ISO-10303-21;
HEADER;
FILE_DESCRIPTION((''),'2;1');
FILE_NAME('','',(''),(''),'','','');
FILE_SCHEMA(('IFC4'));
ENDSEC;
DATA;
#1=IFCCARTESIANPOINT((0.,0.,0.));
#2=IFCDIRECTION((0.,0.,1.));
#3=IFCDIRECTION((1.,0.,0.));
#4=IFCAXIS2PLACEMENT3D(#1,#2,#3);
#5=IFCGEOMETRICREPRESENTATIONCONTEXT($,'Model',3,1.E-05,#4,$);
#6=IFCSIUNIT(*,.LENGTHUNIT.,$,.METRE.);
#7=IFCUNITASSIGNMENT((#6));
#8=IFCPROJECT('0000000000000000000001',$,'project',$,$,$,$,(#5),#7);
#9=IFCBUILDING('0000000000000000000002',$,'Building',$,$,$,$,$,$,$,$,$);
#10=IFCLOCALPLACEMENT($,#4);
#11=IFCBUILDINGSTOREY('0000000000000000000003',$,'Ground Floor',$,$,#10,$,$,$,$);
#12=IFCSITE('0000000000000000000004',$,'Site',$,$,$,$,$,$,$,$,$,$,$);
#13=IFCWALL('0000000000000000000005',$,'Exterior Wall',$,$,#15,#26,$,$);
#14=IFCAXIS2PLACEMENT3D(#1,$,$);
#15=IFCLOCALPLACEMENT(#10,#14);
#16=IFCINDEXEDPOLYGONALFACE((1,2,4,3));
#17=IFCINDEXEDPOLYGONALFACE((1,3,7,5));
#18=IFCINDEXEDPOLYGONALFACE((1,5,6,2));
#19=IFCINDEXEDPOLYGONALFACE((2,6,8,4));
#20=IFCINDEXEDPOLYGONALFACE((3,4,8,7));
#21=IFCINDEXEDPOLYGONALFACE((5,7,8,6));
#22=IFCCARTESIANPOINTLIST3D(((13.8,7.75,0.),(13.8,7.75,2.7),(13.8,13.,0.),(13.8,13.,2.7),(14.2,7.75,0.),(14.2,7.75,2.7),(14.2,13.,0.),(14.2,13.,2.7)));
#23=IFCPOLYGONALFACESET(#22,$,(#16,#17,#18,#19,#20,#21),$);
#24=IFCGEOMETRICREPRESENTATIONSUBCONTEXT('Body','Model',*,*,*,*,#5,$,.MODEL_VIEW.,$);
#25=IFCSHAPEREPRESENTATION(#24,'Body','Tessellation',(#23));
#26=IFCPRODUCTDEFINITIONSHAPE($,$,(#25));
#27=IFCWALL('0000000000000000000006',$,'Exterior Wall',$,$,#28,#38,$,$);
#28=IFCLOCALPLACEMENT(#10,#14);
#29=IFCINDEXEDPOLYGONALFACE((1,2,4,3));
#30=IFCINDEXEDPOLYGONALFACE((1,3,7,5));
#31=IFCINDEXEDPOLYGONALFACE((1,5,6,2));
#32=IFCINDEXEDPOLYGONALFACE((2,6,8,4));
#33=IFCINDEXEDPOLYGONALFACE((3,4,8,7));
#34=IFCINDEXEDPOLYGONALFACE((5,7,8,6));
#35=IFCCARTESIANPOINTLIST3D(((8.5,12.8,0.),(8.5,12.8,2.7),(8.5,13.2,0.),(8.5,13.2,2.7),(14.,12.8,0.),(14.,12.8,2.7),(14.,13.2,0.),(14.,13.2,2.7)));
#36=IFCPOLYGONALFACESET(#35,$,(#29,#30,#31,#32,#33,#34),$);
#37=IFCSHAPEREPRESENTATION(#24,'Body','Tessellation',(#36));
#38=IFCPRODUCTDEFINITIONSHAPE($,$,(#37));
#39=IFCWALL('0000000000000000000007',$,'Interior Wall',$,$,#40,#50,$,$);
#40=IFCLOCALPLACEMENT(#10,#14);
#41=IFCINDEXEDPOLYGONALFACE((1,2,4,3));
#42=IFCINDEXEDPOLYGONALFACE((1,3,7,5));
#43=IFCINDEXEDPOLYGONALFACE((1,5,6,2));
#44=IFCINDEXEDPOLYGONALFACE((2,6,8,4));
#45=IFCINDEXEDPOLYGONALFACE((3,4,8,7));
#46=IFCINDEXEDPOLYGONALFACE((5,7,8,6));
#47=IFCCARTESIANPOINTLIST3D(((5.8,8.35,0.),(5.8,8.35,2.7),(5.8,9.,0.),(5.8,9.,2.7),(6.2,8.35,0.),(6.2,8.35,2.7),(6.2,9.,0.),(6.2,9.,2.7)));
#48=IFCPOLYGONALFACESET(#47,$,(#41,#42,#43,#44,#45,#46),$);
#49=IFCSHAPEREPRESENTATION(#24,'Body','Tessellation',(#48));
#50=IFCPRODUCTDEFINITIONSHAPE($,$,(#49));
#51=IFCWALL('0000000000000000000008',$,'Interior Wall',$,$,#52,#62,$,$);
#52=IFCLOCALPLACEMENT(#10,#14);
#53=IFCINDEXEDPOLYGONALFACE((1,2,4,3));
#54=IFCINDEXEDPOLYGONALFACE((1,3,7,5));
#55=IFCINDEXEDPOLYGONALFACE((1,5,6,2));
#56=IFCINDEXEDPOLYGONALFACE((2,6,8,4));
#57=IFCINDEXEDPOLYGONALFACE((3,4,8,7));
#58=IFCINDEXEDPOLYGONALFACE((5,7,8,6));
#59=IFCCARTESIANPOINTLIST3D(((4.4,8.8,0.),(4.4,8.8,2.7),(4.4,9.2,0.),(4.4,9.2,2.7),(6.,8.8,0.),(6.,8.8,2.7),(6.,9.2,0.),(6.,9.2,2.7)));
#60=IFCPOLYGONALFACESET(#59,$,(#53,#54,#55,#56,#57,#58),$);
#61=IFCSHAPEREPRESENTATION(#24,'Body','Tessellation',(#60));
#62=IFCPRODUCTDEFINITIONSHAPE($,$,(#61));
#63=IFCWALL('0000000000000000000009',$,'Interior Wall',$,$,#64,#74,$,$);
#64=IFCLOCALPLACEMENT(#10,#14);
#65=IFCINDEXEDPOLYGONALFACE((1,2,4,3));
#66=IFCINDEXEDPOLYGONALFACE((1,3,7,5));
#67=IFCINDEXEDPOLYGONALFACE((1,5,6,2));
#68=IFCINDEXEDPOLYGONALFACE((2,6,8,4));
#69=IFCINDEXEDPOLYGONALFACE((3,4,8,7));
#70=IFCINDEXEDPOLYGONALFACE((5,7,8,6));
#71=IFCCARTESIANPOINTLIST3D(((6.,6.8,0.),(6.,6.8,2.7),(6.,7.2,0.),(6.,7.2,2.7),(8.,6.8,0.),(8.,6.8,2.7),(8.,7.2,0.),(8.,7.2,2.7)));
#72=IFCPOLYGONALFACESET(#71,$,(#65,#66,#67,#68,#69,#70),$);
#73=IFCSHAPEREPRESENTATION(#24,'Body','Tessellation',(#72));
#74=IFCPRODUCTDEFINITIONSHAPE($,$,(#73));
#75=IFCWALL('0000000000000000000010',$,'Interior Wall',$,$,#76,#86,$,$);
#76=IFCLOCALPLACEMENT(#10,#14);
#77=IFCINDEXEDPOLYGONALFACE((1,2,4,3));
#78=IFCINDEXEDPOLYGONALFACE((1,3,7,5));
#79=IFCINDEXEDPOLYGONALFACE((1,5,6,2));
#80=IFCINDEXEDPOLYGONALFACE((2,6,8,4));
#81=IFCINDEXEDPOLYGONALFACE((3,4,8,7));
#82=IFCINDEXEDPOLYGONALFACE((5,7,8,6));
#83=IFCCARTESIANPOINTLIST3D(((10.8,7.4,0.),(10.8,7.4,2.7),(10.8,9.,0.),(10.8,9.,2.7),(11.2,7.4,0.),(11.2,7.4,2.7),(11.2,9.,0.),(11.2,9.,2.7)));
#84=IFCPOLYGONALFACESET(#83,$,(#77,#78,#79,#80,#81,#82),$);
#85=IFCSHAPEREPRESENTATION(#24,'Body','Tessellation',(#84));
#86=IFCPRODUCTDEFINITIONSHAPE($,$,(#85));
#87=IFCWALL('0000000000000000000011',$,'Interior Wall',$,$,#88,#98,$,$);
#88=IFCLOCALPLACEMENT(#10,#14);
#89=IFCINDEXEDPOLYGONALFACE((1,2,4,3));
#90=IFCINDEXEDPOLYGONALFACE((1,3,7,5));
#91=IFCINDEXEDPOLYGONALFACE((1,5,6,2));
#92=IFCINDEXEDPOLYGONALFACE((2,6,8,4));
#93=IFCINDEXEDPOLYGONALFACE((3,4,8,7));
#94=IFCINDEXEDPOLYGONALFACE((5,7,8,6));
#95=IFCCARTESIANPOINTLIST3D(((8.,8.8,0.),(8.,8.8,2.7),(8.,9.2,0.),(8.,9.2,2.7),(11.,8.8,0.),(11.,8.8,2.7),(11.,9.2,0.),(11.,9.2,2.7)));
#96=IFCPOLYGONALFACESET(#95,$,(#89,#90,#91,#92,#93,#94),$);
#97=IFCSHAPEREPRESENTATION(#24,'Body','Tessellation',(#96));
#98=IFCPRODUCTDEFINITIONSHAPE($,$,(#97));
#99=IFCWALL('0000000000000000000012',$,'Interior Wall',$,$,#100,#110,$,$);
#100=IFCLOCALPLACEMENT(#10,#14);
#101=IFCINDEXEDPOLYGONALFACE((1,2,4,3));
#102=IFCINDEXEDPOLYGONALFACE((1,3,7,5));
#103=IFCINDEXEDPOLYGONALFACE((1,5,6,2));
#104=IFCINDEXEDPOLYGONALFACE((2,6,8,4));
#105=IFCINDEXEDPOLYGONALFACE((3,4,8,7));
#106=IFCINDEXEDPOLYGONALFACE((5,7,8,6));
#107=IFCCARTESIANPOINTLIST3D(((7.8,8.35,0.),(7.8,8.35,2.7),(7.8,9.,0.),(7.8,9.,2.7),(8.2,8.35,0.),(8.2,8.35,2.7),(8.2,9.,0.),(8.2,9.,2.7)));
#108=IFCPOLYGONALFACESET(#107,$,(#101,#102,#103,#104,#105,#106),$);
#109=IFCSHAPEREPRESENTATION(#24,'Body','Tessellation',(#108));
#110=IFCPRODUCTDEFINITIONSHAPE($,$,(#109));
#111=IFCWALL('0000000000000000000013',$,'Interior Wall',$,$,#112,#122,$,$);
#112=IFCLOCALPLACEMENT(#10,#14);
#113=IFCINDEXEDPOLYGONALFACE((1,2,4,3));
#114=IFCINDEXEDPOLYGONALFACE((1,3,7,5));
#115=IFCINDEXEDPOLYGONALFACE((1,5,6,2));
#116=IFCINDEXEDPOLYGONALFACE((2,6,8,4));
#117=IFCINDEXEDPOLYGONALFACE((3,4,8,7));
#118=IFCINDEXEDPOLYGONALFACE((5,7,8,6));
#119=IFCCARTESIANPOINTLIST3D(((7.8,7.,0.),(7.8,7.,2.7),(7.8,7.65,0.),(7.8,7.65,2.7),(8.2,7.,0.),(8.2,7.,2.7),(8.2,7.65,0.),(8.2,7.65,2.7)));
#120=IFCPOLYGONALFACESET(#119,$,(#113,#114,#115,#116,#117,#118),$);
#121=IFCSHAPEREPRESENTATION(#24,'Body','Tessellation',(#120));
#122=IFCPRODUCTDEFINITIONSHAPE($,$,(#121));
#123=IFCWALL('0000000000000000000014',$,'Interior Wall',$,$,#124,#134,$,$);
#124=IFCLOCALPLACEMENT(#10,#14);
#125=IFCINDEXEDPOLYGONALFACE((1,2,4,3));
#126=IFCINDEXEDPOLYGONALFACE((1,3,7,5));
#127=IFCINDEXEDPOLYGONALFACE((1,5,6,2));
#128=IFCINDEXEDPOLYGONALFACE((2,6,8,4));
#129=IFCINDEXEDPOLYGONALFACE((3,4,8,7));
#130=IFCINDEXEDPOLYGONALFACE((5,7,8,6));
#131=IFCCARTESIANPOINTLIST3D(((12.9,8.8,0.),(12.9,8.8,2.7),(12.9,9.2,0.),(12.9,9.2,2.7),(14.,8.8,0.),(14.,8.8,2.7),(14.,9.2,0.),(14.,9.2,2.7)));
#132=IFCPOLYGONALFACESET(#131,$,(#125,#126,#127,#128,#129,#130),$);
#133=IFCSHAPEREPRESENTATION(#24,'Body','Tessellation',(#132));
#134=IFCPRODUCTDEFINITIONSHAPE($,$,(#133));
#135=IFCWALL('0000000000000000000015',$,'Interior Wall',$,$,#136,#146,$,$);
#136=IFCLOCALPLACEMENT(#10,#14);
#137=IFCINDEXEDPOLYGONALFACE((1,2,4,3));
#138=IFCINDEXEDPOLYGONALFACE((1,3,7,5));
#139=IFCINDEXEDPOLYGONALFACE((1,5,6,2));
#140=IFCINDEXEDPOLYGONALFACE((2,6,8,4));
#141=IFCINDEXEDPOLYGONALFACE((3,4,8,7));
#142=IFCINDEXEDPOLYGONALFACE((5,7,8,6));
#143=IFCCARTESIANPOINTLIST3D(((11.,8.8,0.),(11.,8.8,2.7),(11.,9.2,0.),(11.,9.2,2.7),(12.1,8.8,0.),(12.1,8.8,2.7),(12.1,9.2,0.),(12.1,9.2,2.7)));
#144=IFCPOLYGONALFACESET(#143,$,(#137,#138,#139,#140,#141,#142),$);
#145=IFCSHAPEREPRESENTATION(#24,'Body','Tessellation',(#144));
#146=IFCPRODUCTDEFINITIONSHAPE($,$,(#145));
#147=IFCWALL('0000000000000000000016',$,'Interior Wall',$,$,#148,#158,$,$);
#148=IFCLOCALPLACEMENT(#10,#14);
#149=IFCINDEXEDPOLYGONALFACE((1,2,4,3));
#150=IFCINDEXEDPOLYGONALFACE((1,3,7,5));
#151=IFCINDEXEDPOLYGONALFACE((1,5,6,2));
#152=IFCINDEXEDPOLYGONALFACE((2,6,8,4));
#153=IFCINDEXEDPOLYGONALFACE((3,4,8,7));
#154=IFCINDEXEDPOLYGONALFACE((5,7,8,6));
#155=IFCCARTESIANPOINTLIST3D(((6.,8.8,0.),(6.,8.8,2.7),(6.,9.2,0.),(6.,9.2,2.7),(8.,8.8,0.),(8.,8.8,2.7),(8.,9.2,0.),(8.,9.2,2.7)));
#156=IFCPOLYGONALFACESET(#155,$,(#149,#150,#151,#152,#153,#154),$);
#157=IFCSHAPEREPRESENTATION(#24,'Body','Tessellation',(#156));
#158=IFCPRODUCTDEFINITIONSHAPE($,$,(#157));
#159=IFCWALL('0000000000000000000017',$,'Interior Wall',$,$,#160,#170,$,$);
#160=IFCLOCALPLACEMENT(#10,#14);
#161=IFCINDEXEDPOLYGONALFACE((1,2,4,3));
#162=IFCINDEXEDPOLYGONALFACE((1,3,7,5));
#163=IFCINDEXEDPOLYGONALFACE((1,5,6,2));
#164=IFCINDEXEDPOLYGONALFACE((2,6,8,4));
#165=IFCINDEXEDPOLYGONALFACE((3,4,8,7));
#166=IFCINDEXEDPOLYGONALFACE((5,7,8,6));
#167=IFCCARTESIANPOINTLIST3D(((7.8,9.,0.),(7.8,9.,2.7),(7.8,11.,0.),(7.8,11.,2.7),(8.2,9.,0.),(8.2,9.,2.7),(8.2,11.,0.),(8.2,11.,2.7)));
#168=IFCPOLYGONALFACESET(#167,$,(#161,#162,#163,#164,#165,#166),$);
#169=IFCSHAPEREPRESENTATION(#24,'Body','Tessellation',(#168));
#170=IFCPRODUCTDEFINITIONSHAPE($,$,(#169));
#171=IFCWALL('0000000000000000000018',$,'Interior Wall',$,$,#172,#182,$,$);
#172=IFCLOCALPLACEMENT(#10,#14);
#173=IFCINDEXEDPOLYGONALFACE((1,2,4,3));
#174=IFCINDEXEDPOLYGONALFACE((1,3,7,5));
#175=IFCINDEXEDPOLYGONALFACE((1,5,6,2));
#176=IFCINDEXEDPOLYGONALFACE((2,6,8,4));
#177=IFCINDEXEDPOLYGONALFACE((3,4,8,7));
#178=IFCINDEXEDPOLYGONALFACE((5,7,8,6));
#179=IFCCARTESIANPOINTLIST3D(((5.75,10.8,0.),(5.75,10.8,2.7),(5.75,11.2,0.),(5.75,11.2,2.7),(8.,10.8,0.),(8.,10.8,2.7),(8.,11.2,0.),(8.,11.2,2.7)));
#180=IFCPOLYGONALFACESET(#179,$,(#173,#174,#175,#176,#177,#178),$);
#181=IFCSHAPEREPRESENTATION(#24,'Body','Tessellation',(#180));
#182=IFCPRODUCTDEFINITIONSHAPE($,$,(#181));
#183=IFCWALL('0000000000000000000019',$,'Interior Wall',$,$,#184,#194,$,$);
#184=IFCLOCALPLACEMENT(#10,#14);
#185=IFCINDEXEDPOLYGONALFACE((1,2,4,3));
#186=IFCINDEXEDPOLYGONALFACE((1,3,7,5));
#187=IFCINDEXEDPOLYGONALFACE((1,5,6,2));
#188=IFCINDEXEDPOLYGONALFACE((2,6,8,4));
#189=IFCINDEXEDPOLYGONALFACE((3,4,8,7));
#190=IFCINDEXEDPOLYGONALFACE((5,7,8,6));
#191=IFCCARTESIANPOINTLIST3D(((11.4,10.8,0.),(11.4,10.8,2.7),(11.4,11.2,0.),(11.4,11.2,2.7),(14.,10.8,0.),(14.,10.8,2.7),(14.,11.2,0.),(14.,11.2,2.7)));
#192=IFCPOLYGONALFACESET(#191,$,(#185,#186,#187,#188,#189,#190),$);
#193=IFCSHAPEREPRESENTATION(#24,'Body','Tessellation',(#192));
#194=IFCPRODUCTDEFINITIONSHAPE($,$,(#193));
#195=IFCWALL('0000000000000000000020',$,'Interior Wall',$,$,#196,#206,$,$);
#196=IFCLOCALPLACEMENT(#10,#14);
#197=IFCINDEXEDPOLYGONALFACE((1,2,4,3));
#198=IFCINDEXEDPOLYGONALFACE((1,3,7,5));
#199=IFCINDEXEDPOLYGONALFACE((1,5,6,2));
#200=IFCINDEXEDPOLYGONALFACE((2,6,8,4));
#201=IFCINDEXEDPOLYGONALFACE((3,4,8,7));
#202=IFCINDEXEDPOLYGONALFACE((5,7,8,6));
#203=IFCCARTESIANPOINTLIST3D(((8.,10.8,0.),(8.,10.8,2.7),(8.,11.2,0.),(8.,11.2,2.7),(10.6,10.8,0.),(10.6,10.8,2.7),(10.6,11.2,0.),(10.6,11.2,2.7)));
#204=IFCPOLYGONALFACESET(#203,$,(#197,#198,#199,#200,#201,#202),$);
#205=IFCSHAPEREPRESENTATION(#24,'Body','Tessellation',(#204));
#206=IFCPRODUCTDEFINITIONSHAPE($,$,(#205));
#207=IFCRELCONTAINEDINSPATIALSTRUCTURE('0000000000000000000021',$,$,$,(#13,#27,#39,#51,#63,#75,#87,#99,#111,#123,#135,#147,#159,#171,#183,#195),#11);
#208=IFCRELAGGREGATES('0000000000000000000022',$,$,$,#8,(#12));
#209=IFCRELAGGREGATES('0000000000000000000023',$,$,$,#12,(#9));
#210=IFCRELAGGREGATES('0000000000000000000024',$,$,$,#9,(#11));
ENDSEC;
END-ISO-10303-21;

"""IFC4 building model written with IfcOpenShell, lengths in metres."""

from ifc_helpers import new_model, si_unit, frame, origin_with_axes, place, context, subcontext, project, spatial, indexed_curve, outline, extrude, element, save


model = new_model("IFC4")

# Units and contexts
model_context = context("Model", 3, precision=1e-05, world=origin_with_axes())
body_context = subcontext(model_context, "Body", "Model", "MODEL_VIEW")
ifc_project = project(units=[si_unit("LENGTHUNIT", "METRE")], contexts=[model_context])

# Site, building, storey
site = spatial("IfcSite", under=ifc_project, Name="Site")
building = spatial("IfcBuilding", under=site, Name="Building")
storey_placement = place(None, origin_with_axes())
storey = spatial("IfcBuildingStorey", under=building, at=storey_placement, Name="Ground Floor")

# Walls
wall_1_placement = place(storey_placement, frame((14.0, 7.75, 0.0), z_axis=(0.0, 0.0, 1.0), x_axis=(0.0, 1.0, 0.0)))
element("IfcWall", 1, at=wall_1_placement, inside=storey, Name="Exterior Wall", context=body_context, shape_type="SweptSolid", body=[
    extrude(outline(indexed_curve([(0.0, 0.0), (0.0, 0.4), (5.25, 0.4), (5.25, 0.0), (0.0, 0.0)], self_intersect=False)), frame((0.0, -0.2, 0.0), z_axis=(0.0, 0.0, 1.0), x_axis=(1.0, 0.0, 0.0)), (0.0, 0.0, 1.0), 2.7),
])
wall_2_placement = place(storey_placement, frame((14.0, 13.0, 0.0), z_axis=(0.0, 0.0, 1.0), x_axis=(-1.0, 0.0, 0.0)))
element("IfcWall", 2, at=wall_2_placement, inside=storey, Name="Exterior Wall", context=body_context, shape_type="SweptSolid", body=[
    extrude(outline(indexed_curve([(0.0, 0.0), (0.0, 0.4), (5.5, 0.4), (5.5, 0.0), (0.0, 0.0)], self_intersect=False)), frame((0.0, -0.2, 0.0), z_axis=(0.0, 0.0, 1.0), x_axis=(1.0, 0.0, 0.0)), (0.0, 0.0, 1.0), 2.7),
])
wall_3_placement = place(storey_placement, frame((6.0, 8.35, 0.0), z_axis=(0.0, 0.0, 1.0), x_axis=(0.0, 1.0, 0.0)))
element("IfcWall", 3, at=wall_3_placement, inside=storey, Name="Interior Wall", context=body_context, shape_type="SweptSolid", body=[
    extrude(outline(indexed_curve([(0.0, 0.0), (0.0, 0.4), (0.65, 0.4), (0.65, 0.0), (0.0, 0.0)], self_intersect=False)), frame((0.0, -0.2, 0.0), z_axis=(0.0, 0.0, 1.0), x_axis=(1.0, 0.0, 0.0)), (0.0, 0.0, 1.0), 2.7),
])
wall_4_placement = place(storey_placement, frame((6.0, 9.0, 0.0), z_axis=(0.0, 0.0, 1.0), x_axis=(-1.0, 0.0, 0.0)))
element("IfcWall", 4, at=wall_4_placement, inside=storey, Name="Interior Wall", context=body_context, shape_type="SweptSolid", body=[
    extrude(outline(indexed_curve([(0.0, 0.0), (0.0, 0.4), (1.6, 0.4), (1.6, 0.0), (0.0, 0.0)], self_intersect=False)), frame((0.0, -0.2, 0.0), z_axis=(0.0, 0.0, 1.0), x_axis=(1.0, 0.0, 0.0)), (0.0, 0.0, 1.0), 2.7),
])
wall_5_placement = place(storey_placement, frame((8.0, 7.0, 0.0), z_axis=(0.0, 0.0, 1.0), x_axis=(-1.0, 0.0, 0.0)))
element("IfcWall", 5, at=wall_5_placement, inside=storey, Name="Interior Wall", context=body_context, shape_type="SweptSolid", body=[
    extrude(outline(indexed_curve([(0.0, 0.0), (0.0, 0.4), (2.0, 0.4), (2.0, 0.0), (0.0, 0.0)], self_intersect=False)), frame((0.0, -0.2, 0.0), z_axis=(0.0, 0.0, 1.0), x_axis=(1.0, 0.0, 0.0)), (0.0, 0.0, 1.0), 2.7),
])
wall_6_placement = place(storey_placement, frame((11.0, 7.4, 0.0), z_axis=(0.0, 0.0, 1.0), x_axis=(0.0, 1.0, 0.0)))
element("IfcWall", 6, at=wall_6_placement, inside=storey, Name="Interior Wall", context=body_context, shape_type="SweptSolid", body=[
    extrude(outline(indexed_curve([(0.0, 0.0), (0.0, 0.4), (1.6, 0.4), (1.6, 0.0), (0.0, 0.0)], self_intersect=False)), frame((0.0, -0.2, 0.0), z_axis=(0.0, 0.0, 1.0), x_axis=(1.0, 0.0, 0.0)), (0.0, 0.0, 1.0), 2.7),
])
wall_7_placement = place(storey_placement, frame((11.0, 9.0, 0.0), z_axis=(0.0, 0.0, 1.0), x_axis=(-1.0, 0.0, 0.0)))
element("IfcWall", 7, at=wall_7_placement, inside=storey, Name="Interior Wall", context=body_context, shape_type="SweptSolid", body=[
    extrude(outline(indexed_curve([(0.0, 0.0), (0.0, 0.4), (3.0, 0.4), (3.0, 0.0), (0.0, 0.0)], self_intersect=False)), frame((0.0, -0.2, 0.0), z_axis=(0.0, 0.0, 1.0), x_axis=(1.0, 0.0, 0.0)), (0.0, 0.0, 1.0), 2.7),
])
for number, where, z_axis, x_axis, name in (
    (8, (8.0, 9.0, 0.0), (0.0, 0.0, 1.0), (0.0, -1.0, 0.0), "Interior Wall"),
    (9, (8.0, 7.65, 0.0), (0.0, 0.0, 1.0), (0.0, -1.0, 0.0), "Interior Wall"),
):
    element("IfcWall", number, at=place(storey_placement, frame(where, z_axis=z_axis, x_axis=x_axis)), inside=storey, Name=name, context=body_context, shape_type="SweptSolid", body=[
        extrude(outline(indexed_curve([(0.0, 0.0), (0.0, 0.4), (0.65, 0.4), (0.65, 0.0), (0.0, 0.0)], self_intersect=False)), frame((0.0, -0.2, 0.0), z_axis=(0.0, 0.0, 1.0), x_axis=(1.0, 0.0, 0.0)), (0.0, 0.0, 1.0), 2.7),
    ])
for number, where, z_axis, x_axis, name in (
    (10, (14.0, 9.0, 0.0), (0.0, 0.0, 1.0), (-1.0, 0.0, 0.0), "Interior Wall"),
    (11, (12.1, 9.0, 0.0), (0.0, 0.0, 1.0), (-1.0, 0.0, 0.0), "Interior Wall"),
):
    element("IfcWall", number, at=place(storey_placement, frame(where, z_axis=z_axis, x_axis=x_axis)), inside=storey, Name=name, context=body_context, shape_type="SweptSolid", body=[
        extrude(outline(indexed_curve([(0.0, 0.0), (0.0, 0.4), (1.1, 0.4), (1.1, 0.0), (0.0, 0.0)], self_intersect=False)), frame((0.0, -0.2, 0.0), z_axis=(0.0, 0.0, 1.0), x_axis=(1.0, 0.0, 0.0)), (0.0, 0.0, 1.0), 2.7),
    ])
for number, where, z_axis, x_axis, name in (
    (12, (8.0, 9.0, 0.0), (0.0, 0.0, 1.0), (-1.0, 0.0, 0.0), "Interior Wall"),
    (13, (8.0, 9.0, 0.0), (0.0, 0.0, 1.0), (0.0, 1.0, 0.0), "Interior Wall"),
):
    element("IfcWall", number, at=place(storey_placement, frame(where, z_axis=z_axis, x_axis=x_axis)), inside=storey, Name=name, context=body_context, shape_type="SweptSolid", body=[
        extrude(outline(indexed_curve([(0.0, 0.0), (0.0, 0.4), (2.0, 0.4), (2.0, 0.0), (0.0, 0.0)], self_intersect=False)), frame((0.0, -0.2, 0.0), z_axis=(0.0, 0.0, 1.0), x_axis=(1.0, 0.0, 0.0)), (0.0, 0.0, 1.0), 2.7),
    ])
wall_8_placement = place(storey_placement, frame((8.0, 11.0, 0.0), z_axis=(0.0, 0.0, 1.0), x_axis=(-1.0, 0.0, 0.0)))
element("IfcWall", 14, at=wall_8_placement, inside=storey, Name="Interior Wall", context=body_context, shape_type="SweptSolid", body=[
    extrude(outline(indexed_curve([(0.0, 0.0), (0.0, 0.4), (2.25, 0.4), (2.25, 0.0), (0.0, 0.0)], self_intersect=False)), frame((0.0, -0.2, 0.0), z_axis=(0.0, 0.0, 1.0), x_axis=(1.0, 0.0, 0.0)), (0.0, 0.0, 1.0), 2.7),
])
for number, where, z_axis, x_axis, name in (
    (15, (14.0, 11.0, 0.0), (0.0, 0.0, 1.0), (-1.0, 0.0, 0.0), "Interior Wall"),
    (16, (10.6, 11.0, 0.0), (0.0, 0.0, 1.0), (-1.0, 0.0, 0.0), "Interior Wall"),
):
    element("IfcWall", number, at=place(storey_placement, frame(where, z_axis=z_axis, x_axis=x_axis)), inside=storey, Name=name, context=body_context, shape_type="SweptSolid", body=[
        extrude(outline(indexed_curve([(0.0, 0.0), (0.0, 0.4), (2.6, 0.4), (2.6, 0.0), (0.0, 0.0)], self_intersect=False)), frame((0.0, -0.2, 0.0), z_axis=(0.0, 0.0, 1.0), x_axis=(1.0, 0.0, 0.0)), (0.0, 0.0, 1.0), 2.7),
    ])

save(model, "model.ifc")
